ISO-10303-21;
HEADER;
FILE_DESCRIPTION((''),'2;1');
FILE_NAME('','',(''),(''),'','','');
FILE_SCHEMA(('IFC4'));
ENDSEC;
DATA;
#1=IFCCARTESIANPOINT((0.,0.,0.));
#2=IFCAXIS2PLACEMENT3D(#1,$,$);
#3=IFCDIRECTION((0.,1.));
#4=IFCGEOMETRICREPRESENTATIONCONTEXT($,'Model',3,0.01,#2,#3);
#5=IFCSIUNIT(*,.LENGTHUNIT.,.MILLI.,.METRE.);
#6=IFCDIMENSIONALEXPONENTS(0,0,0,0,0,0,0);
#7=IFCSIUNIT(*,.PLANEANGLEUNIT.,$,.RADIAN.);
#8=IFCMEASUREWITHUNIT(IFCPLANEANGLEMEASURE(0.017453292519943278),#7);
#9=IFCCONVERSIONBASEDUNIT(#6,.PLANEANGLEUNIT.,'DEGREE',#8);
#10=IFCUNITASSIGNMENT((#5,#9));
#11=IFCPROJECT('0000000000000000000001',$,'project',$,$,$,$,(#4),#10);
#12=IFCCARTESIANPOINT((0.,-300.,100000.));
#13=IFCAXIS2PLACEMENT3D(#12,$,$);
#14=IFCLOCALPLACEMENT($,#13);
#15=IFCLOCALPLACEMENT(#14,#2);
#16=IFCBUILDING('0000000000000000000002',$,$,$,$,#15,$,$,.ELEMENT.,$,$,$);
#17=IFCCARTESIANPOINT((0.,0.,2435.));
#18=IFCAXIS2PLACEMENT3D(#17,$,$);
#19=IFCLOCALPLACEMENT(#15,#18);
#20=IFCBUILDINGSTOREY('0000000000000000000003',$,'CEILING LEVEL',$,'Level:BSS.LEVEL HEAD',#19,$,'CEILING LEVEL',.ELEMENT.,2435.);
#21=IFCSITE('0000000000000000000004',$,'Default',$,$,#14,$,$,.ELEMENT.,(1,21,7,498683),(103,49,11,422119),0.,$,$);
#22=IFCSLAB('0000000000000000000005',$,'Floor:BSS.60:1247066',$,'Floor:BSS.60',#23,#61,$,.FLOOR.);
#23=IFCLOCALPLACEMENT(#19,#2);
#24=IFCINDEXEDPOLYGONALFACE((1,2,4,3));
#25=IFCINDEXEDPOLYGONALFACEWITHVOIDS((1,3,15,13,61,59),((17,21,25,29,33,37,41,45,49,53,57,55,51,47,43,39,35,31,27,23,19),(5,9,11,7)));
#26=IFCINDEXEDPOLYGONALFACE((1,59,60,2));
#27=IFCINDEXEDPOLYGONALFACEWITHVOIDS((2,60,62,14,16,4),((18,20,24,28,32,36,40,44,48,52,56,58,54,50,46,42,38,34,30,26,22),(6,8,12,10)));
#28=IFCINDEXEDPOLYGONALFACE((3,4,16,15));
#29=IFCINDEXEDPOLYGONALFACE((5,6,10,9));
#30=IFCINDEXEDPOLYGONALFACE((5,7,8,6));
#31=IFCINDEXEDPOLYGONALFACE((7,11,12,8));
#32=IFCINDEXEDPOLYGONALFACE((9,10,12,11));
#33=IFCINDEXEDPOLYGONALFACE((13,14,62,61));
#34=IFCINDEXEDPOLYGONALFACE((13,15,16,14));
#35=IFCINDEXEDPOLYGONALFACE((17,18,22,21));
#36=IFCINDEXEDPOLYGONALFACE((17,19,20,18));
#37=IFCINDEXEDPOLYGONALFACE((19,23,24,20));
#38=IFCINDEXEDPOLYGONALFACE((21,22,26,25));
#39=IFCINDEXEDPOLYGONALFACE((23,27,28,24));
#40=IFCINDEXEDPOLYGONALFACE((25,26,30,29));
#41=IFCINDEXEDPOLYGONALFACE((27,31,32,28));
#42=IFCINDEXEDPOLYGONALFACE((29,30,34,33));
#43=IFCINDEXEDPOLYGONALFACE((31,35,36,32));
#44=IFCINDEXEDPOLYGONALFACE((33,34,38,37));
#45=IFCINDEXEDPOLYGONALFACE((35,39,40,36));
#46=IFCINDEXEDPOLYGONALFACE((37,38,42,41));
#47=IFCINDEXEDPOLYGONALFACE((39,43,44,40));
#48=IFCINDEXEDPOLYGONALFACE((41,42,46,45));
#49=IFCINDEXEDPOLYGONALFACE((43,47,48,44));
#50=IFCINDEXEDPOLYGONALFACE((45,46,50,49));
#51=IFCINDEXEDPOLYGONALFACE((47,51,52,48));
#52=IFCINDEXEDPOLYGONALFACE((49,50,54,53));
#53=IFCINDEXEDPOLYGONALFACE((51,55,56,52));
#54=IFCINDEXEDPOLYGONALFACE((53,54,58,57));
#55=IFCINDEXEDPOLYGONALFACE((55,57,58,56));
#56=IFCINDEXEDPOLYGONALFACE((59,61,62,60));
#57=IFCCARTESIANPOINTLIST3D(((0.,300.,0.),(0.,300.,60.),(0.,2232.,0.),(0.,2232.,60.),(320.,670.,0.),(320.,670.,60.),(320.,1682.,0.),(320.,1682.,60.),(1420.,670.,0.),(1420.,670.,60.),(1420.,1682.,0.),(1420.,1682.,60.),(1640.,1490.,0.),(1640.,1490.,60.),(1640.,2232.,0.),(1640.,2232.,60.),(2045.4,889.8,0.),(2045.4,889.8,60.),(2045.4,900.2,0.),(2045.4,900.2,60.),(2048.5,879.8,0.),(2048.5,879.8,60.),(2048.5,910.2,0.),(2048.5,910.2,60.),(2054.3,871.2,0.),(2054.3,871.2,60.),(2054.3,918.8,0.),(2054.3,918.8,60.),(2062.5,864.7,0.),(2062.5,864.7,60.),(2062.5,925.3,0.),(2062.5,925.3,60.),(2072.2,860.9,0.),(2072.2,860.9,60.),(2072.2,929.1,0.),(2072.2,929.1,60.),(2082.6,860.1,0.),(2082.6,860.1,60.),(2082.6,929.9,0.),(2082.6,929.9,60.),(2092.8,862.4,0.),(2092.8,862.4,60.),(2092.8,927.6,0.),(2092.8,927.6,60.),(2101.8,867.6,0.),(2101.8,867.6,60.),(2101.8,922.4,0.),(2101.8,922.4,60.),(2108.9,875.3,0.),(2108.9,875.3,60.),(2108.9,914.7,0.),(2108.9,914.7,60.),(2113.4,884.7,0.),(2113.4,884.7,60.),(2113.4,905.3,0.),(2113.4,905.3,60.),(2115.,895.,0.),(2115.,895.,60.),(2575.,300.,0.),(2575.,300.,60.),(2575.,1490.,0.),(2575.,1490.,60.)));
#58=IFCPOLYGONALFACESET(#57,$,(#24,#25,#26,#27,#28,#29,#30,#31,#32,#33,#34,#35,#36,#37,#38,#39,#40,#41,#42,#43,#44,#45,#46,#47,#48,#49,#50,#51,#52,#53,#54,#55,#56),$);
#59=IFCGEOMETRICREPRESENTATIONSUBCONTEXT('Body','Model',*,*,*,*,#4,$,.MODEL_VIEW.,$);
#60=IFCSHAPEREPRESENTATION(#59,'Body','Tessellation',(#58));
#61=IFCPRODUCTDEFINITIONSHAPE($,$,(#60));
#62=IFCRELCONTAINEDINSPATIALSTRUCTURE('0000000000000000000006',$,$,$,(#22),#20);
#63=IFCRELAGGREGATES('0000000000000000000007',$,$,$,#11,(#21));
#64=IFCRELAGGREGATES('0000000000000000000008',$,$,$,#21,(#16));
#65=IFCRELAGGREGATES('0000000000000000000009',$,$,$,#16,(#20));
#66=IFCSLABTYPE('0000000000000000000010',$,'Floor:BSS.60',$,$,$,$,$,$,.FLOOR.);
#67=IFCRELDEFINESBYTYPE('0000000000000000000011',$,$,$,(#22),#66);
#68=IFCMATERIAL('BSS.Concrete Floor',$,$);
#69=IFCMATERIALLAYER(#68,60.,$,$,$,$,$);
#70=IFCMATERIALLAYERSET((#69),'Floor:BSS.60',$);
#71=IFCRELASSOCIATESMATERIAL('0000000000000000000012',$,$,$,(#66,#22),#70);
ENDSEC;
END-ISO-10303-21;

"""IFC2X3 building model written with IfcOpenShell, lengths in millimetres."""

from ifc_helpers import new_model, entity, si_unit, converted_unit, direction, frame, origin, origin_2d_with_axis, place, context, subcontext, project, spatial, polyline, rectangle, circle, outline, extrude, material, layer, layer_set, layer_usage, type_object, element, save


model = new_model("IFC2X3")

# Units and contexts
model_context = context("Model", 3, precision=0.01, world=origin(), true_north=direction((0.0, 1.0)))
body_context = subcontext(model_context, "Body", "Model", "MODEL_VIEW")
ifc_project = project(units=[si_unit("LENGTHUNIT", "METRE", prefix="MILLI"), converted_unit("PLANEANGLEUNIT", "DEGREE", entity("IfcPlaneAngleMeasure", 0.017453292519943278), si_unit("PLANEANGLEUNIT", "RADIAN"), dimensions=[0, 0, 0, 0, 0, 0, 0])], contexts=[model_context])

# Site, building, storey
site_placement = place(None, frame((0.0, -300.0, 100000.0)))
site = spatial("IfcSite", under=ifc_project, at=site_placement, Name="Default", CompositionType="ELEMENT", RefLatitude=(1, 21, 7, 498683), RefLongitude=(103, 49, 11, 422119), RefElevation=0.0)
building_placement = place(site_placement, origin())
building = spatial("IfcBuilding", under=site, at=building_placement, CompositionType="ELEMENT")
storey_placement = place(building_placement, frame((0.0, 0.0, 2435.0)))
storey = spatial("IfcBuildingStorey", under=building, at=storey_placement, Name="CEILING LEVEL", ObjectType="Level:BSS.LEVEL HEAD", LongName="CEILING LEVEL", CompositionType="ELEMENT", Elevation=2435.0)

# Slab, openings
ifc_material = material(Name="BSS.Concrete Floor")
ifc_layer = layer(ifc_material, 60.0)
ifc_layer_set = layer_set([ifc_layer], Name="Floor:BSS.60")
ifc_layer_usage = layer_usage(ifc_layer_set, "AXIS3", "POSITIVE", 0.0)
slab_type = type_object("IfcSlabType", Name="Floor:BSS.60", PredefinedType="FLOOR", material=ifc_layer_set)
slab_placement = place(storey_placement, frame((0.0, 300.0, 0.0)))
slab = element("IfcSlab", 1, at=slab_placement, inside=storey, type_object=slab_type, material=ifc_layer_usage, Name="Floor:BSS.60:1247066", ObjectType="Floor:BSS.60", PredefinedType="FLOOR", context=body_context, shape_type="SweptSolid", body=[
    extrude(outline(polyline([(1287.5, -966.0), (1287.5, 966.0), (-352.5, 966.0), (-352.5, 224.0), (-1287.5, 224.0), (-1287.5, -966.0), (1287.5, -966.0)])), frame((1287.5, 966.0, 60.0), z_axis=(0.0, 0.0, -1.0), x_axis=(-1.0, 0.0, 0.0)), (0.0, 0.0, 1.0), 60.0),
])
opening_1_placement = place(slab_placement, origin())
element("IfcOpeningElement", 2, at=opening_1_placement, cuts=slab, ObjectType="Opening", context=body_context, shape_type="SweptSolid", body=[
    extrude(rectangle(XDim=1012.0, YDim=1100.0, at=origin_2d_with_axis()), frame((870.0, 876.0, 60.0), z_axis=(0.0, 0.0, -1.0), x_axis=(0.0, -1.0, 0.0)), (0.0, 0.0, 1.0), 60.0),
])
opening_2_placement = place(slab_placement, origin())
element("IfcOpeningElement", 3, at=opening_2_placement, cuts=slab, ObjectType="Opening", context=body_context, shape_type="SweptSolid", body=[
    extrude(circle(Radius=35.0, at=origin_2d_with_axis()), frame((2080.0, 595.0, 60.0), z_axis=(0.0, 0.0, -1.0), x_axis=(1.0, 0.0, 0.0)), (0.0, 0.0, 1.0), 60.0),
])

save(model, "model.ifc")
